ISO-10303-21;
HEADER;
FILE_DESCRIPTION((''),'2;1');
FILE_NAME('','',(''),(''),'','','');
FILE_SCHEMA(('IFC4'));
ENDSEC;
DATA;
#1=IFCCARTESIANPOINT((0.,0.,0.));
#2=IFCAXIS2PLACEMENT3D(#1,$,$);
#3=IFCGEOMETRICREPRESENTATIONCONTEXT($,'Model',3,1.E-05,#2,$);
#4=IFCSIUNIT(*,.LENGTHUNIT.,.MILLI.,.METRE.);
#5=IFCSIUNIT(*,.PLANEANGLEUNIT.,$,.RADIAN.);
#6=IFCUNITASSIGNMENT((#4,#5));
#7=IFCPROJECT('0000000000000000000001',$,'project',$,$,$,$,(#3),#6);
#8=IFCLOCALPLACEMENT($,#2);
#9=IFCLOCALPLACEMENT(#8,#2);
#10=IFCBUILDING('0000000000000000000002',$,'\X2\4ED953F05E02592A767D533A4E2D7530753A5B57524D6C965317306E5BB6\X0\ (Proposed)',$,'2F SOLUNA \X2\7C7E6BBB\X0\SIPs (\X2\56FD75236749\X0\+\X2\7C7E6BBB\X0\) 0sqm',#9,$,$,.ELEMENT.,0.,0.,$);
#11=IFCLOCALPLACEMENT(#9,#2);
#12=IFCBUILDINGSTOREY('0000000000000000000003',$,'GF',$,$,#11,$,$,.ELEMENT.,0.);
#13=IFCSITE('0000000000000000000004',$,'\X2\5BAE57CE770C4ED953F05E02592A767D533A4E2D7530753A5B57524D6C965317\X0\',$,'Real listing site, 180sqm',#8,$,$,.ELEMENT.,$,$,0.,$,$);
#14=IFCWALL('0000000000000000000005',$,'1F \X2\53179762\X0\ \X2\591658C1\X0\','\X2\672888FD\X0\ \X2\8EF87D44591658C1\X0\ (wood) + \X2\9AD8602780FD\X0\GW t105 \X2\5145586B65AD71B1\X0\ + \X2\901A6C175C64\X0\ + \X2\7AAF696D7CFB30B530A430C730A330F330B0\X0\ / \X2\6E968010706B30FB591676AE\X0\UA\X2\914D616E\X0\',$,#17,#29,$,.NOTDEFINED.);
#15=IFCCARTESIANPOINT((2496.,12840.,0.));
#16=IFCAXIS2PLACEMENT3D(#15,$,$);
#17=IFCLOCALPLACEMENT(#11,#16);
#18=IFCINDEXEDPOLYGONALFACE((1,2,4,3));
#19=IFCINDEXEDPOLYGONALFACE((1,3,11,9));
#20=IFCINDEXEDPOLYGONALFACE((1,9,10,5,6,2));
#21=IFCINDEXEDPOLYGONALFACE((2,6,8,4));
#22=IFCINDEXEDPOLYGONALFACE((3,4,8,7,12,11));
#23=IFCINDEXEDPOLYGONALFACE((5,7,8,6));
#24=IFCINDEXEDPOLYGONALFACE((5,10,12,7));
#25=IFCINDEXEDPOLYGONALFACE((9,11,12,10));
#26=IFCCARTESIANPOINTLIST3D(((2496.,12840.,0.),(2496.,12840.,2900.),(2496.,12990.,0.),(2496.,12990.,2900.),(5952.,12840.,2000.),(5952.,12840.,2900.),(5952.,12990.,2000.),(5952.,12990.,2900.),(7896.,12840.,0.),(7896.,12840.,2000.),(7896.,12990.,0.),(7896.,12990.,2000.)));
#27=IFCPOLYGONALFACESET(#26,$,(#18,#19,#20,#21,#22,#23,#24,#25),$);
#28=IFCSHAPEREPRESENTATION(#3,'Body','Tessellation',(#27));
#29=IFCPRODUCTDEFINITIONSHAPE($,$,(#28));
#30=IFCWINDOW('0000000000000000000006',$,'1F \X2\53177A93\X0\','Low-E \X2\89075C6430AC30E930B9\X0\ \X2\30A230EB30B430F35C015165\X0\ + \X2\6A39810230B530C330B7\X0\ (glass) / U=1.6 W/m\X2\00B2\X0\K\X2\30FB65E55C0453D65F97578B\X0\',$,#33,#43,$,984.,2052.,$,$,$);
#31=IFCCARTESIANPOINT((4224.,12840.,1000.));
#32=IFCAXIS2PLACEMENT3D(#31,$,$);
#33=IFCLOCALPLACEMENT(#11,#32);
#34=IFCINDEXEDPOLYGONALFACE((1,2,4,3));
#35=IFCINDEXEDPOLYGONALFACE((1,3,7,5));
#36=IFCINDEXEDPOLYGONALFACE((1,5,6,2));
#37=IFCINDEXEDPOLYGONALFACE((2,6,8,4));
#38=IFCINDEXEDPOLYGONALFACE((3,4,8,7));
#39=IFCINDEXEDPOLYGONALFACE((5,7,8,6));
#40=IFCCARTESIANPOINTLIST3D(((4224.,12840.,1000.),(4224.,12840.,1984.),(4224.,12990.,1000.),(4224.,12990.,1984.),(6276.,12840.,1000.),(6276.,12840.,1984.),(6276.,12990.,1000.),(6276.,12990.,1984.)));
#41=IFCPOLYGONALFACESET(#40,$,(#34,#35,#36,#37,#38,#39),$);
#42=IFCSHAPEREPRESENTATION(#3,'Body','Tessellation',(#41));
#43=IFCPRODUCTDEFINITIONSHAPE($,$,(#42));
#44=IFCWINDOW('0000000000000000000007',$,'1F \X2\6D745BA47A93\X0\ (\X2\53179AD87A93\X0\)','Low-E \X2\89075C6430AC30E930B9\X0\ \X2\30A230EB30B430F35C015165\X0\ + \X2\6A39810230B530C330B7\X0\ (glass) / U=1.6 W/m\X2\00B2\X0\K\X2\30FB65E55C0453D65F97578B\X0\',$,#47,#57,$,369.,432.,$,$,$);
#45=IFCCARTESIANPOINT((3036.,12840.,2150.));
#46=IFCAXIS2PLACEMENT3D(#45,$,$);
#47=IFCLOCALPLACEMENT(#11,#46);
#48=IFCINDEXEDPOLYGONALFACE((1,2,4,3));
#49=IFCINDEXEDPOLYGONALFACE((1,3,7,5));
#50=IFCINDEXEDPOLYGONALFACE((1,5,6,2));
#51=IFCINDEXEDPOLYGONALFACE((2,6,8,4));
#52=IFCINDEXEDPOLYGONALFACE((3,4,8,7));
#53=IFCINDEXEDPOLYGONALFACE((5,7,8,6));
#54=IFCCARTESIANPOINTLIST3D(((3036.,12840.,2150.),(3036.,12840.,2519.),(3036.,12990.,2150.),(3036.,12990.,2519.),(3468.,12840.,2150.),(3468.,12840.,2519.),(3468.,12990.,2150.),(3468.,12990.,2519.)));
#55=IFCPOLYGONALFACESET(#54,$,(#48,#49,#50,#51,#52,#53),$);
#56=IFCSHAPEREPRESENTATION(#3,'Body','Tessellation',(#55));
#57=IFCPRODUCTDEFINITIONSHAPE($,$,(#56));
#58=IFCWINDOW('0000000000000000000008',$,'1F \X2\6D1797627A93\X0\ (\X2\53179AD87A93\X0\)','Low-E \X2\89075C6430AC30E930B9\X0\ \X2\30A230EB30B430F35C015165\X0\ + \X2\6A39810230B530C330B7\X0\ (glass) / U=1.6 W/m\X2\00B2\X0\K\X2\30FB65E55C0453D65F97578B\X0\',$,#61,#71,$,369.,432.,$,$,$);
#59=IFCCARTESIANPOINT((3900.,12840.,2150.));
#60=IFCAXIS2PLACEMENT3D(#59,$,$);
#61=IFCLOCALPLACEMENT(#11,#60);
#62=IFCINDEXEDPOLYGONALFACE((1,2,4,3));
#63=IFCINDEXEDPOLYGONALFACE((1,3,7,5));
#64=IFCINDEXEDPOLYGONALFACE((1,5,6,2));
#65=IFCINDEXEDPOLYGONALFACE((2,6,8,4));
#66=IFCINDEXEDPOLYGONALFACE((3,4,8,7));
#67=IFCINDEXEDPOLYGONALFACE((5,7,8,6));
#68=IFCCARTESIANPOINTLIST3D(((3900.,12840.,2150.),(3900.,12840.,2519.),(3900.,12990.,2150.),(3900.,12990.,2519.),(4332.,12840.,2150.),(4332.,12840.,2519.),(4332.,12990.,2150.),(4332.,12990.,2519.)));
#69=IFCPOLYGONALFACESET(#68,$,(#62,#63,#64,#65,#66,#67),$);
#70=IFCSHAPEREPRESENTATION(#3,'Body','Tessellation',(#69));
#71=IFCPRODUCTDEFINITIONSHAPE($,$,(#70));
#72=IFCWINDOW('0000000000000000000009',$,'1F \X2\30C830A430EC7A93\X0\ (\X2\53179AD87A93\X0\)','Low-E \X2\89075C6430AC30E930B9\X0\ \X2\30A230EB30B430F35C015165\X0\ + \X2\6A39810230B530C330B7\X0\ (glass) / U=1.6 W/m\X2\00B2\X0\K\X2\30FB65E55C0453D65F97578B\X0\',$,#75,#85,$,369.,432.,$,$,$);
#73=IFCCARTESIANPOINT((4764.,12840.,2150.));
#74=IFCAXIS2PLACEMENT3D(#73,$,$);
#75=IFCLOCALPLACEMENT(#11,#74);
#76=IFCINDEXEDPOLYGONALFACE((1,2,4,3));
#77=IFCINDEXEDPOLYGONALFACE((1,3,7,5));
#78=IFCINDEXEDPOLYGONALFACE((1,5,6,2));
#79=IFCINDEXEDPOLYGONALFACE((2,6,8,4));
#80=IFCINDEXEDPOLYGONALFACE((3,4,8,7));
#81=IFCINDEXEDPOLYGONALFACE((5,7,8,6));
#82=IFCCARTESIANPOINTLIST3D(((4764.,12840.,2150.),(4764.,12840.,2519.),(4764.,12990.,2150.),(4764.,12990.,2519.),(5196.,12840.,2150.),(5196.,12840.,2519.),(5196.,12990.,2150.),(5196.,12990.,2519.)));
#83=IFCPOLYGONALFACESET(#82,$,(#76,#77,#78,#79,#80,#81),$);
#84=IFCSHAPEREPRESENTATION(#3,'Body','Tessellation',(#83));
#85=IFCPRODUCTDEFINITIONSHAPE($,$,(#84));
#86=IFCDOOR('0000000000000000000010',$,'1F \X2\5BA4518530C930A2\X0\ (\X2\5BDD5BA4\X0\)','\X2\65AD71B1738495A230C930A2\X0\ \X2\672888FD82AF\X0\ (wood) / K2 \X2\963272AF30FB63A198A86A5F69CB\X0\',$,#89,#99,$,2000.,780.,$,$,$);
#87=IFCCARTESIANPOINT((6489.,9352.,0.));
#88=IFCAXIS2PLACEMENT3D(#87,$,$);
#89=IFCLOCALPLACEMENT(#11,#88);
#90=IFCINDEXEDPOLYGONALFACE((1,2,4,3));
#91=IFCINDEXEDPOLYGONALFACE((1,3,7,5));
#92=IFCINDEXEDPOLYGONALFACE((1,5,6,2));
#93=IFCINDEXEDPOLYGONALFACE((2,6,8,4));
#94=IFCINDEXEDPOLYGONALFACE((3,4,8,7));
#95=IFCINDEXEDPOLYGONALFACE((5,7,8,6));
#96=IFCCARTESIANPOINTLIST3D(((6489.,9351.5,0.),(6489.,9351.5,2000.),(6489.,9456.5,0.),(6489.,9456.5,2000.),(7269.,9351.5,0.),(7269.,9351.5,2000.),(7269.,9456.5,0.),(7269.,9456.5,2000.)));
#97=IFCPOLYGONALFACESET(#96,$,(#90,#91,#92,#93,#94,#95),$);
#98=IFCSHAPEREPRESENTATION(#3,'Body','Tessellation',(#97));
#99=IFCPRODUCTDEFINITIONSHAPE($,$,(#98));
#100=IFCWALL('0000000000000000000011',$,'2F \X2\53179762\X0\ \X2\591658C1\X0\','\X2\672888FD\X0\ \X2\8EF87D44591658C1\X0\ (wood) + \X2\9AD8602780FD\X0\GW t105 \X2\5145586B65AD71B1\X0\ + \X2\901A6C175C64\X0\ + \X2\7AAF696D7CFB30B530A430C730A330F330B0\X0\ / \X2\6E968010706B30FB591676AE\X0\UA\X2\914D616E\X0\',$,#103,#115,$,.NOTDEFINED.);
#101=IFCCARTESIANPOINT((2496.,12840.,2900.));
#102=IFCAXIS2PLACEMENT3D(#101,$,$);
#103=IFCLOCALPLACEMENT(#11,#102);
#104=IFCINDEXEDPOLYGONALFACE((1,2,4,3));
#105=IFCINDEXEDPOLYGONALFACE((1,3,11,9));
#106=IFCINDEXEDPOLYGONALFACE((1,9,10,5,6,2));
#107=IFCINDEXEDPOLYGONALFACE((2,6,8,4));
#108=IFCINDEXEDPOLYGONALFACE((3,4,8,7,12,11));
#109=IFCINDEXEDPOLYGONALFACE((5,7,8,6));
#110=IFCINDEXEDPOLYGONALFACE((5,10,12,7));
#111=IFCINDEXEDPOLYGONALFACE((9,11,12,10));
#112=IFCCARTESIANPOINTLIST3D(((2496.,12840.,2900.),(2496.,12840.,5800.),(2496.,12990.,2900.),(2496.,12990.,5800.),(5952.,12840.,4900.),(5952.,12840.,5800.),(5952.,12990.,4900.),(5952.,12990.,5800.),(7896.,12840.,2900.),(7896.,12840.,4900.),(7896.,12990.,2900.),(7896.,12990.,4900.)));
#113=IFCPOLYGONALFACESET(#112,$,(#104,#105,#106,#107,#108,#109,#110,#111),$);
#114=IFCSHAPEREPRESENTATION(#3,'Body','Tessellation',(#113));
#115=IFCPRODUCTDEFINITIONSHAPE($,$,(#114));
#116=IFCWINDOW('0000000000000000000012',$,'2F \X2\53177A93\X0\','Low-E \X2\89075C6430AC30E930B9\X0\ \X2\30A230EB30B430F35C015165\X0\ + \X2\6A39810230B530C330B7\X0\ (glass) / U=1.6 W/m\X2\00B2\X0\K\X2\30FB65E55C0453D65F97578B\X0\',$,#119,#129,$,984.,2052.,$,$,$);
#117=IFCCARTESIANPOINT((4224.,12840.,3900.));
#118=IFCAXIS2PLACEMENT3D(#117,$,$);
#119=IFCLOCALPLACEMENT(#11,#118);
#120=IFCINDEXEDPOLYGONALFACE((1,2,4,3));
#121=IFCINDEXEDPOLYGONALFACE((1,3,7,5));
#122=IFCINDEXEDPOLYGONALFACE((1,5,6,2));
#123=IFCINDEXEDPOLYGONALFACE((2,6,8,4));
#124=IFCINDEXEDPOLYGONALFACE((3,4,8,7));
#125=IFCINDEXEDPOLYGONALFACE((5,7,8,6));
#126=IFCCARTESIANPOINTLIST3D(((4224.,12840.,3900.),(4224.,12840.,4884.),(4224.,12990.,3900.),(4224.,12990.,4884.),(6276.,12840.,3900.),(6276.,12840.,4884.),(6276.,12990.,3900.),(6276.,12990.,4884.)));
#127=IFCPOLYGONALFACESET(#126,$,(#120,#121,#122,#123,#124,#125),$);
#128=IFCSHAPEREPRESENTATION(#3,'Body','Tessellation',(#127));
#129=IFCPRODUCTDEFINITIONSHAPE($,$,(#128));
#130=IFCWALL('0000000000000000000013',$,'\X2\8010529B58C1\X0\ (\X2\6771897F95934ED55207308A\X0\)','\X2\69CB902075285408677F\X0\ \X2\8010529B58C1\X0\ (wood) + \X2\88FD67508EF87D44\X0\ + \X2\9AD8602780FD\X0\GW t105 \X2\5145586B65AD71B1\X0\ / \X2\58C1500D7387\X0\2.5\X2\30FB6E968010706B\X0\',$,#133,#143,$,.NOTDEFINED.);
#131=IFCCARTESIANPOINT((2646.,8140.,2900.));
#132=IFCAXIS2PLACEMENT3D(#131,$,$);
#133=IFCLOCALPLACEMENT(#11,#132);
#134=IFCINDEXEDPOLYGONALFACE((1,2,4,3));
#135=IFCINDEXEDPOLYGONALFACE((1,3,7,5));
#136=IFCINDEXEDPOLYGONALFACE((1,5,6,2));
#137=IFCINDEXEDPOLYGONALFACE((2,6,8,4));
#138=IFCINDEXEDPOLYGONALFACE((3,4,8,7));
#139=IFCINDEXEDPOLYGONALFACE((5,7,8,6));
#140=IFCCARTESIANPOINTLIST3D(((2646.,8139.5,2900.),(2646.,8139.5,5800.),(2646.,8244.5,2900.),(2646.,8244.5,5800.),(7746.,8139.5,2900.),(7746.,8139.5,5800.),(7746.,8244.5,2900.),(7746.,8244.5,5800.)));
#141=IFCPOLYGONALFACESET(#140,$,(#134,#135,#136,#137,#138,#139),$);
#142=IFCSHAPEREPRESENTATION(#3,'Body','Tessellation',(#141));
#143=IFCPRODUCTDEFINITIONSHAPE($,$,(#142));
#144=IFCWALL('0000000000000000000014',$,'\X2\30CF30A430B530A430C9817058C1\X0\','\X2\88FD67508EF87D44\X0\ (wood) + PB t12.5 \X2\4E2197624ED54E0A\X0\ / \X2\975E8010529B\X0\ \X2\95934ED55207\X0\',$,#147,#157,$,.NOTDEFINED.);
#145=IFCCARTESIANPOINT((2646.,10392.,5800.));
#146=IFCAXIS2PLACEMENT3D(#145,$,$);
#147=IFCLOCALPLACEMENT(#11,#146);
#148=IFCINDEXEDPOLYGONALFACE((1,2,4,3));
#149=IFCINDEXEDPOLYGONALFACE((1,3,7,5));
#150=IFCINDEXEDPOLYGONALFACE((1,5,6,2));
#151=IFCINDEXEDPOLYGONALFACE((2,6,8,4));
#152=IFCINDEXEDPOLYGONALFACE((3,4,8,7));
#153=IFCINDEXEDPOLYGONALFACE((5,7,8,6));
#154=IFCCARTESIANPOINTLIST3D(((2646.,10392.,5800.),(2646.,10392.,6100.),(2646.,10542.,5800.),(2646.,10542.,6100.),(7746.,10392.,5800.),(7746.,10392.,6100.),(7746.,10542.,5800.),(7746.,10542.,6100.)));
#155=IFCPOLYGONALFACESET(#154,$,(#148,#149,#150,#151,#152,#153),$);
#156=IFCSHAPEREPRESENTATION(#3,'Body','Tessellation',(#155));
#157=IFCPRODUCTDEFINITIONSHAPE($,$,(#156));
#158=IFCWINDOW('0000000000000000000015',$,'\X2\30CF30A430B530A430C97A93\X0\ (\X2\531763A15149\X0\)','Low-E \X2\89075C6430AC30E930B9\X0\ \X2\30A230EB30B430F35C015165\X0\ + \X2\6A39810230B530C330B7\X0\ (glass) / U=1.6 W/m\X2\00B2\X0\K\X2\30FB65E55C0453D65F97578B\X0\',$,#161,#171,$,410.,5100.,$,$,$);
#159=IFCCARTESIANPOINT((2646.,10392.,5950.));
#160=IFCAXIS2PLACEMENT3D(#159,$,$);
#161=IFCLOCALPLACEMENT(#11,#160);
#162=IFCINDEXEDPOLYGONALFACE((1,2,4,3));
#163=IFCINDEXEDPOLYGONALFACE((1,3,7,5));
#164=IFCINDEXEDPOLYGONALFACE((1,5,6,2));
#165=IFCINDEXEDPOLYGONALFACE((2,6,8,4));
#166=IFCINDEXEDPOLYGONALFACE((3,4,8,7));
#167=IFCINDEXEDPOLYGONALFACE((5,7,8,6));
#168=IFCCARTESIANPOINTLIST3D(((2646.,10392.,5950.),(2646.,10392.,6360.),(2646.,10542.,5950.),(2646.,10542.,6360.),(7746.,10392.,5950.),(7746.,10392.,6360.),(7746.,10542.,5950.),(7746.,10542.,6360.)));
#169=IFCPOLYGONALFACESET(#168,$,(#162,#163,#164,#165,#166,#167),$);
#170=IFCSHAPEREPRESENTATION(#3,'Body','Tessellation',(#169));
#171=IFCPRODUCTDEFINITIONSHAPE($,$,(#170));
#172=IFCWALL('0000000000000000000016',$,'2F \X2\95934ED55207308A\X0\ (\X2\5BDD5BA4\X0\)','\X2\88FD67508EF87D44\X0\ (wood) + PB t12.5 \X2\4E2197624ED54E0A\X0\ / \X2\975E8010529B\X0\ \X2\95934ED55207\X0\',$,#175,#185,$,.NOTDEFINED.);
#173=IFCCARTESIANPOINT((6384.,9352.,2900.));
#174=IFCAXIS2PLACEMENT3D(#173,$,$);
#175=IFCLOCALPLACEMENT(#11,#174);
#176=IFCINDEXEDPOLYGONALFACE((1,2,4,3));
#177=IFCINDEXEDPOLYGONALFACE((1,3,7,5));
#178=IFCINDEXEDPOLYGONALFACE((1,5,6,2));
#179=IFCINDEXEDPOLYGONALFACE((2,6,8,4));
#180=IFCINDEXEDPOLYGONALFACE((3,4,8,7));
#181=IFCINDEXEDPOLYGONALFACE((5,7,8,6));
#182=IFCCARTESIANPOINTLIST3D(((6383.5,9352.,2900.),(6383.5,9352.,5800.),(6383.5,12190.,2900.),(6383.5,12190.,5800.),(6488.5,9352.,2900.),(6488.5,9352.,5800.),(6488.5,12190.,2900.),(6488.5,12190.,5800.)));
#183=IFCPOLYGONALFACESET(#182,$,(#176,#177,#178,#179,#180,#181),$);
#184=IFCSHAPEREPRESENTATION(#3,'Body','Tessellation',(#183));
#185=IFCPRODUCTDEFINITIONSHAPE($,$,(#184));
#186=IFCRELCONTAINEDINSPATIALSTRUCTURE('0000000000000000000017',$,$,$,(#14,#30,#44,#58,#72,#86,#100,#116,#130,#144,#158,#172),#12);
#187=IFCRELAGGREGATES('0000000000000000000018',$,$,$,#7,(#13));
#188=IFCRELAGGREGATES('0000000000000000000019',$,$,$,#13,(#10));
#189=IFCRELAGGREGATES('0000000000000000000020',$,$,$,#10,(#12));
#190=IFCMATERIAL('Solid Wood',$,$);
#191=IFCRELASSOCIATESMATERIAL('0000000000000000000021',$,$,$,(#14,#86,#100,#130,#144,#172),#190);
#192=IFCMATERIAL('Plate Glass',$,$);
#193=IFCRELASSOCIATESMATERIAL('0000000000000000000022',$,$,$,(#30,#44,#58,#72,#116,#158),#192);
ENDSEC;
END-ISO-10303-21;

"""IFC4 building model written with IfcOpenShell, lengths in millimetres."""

from ifc_helpers import new_model, si_unit, frame, frame_2d, origin, place, context, project, spatial, rectangle, extrude, material, element, fill, save


model = new_model("IFC4")

# Units and contexts
model_context = context("Model", 3, precision=1e-05, world=origin())
ifc_project = project(units=[si_unit("LENGTHUNIT", "METRE", prefix="MILLI"), si_unit("PLANEANGLEUNIT", "RADIAN")], contexts=[model_context])

# Site, building, storey
site_placement = place(None, origin())
site = spatial("IfcSite", under=ifc_project, at=site_placement, Name="宮城県仙台市太白区中田町字前沖北", ObjectType="Real listing site, 180sqm", CompositionType="ELEMENT", RefElevation=0.0)
building_placement = place(site_placement, origin())
building = spatial("IfcBuilding", under=site, at=building_placement, Name="仙台市太白区中田町字前沖北の家 (Proposed)", ObjectType="2F SOLUNA 籾殻SIPs (国産杉+籾殻) 0sqm", CompositionType="ELEMENT", ElevationOfRefHeight=0.0, ElevationOfTerrain=0.0)
storey_placement = place(building_placement, origin())
storey = spatial("IfcBuildingStorey", under=building, at=storey_placement, Name="GF", CompositionType="ELEMENT", Elevation=0.0)

# Wall, openings, windows
ifc_material_1 = material(Name="Solid Wood")
wall_1_placement = place(storey_placement, frame((2496.0, 12840.0, 0.0)))
wall_1 = element("IfcWall", 1, at=wall_1_placement, inside=storey, material=ifc_material_1, Name="1F 北面 外壁", Description="木製 軸組外壁 (wood) + 高性能GW t105 充填断熱 + 通気層 + 窯業系サイディング / 準耐火・外皮UA配慮", PredefinedType="NOTDEFINED", context=model_context, shape_type="SweptSolid", body=[
    extrude(rectangle(XDim=5400.0, YDim=150.0, at=frame_2d((2700.0, 75.0))), frame((2496.0, 12840.0, 0.0)), (0.0, 0.0, 1.0), 2900.0),
])
opening_1_placement = place(storey_placement, frame((4224.0, 12840.0, 1000.0)))
opening_1 = element("IfcOpeningElement", 2, at=opening_1_placement, cuts=wall_1, PredefinedType="NOTDEFINED", context=model_context, shape_type="SweptSolid", body=[
    extrude(rectangle(XDim=2052.0, YDim=150.0, at=frame_2d((1026.0, 75.0))), frame((4224.0, 12840.0, 1000.0)), (0.0, 0.0, 1.0), 984.0),
])
opening_2_placement = place(storey_placement, frame((3036.0, 12840.0, 2150.0)))
opening_2 = element("IfcOpeningElement", 3, at=opening_2_placement, cuts=wall_1, PredefinedType="NOTDEFINED", context=model_context, shape_type="SweptSolid", body=[
    extrude(rectangle(XDim=432.0, YDim=150.0, at=frame_2d((216.0, 75.0))), frame((3036.0, 12840.0, 2150.0)), (0.0, 0.0, 1.0), 369.0),
])
opening_3_placement = place(storey_placement, frame((3900.0, 12840.0, 2150.0)))
opening_3 = element("IfcOpeningElement", 4, at=opening_3_placement, cuts=wall_1, PredefinedType="NOTDEFINED", context=model_context, shape_type="SweptSolid", body=[
    extrude(rectangle(XDim=432.0, YDim=150.0, at=frame_2d((216.0, 75.0))), frame((3900.0, 12840.0, 2150.0)), (0.0, 0.0, 1.0), 369.0),
])
opening_4_placement = place(storey_placement, frame((4764.0, 12840.0, 2150.0)))
opening_4 = element("IfcOpeningElement", 5, at=opening_4_placement, cuts=wall_1, PredefinedType="NOTDEFINED", context=model_context, shape_type="SweptSolid", body=[
    extrude(rectangle(XDim=432.0, YDim=150.0, at=frame_2d((216.0, 75.0))), frame((4764.0, 12840.0, 2150.0)), (0.0, 0.0, 1.0), 369.0),
])
ifc_material_2 = material(Name="Plate Glass")
window_1_placement = place(storey_placement, frame((4224.0, 12840.0, 1000.0)))
window_1 = element("IfcWindow", 6, at=window_1_placement, inside=storey, material=ifc_material_2, Name="1F 北窓", Description="Low-E 複層ガラス アルゴン封入 + 樹脂サッシ (glass) / U=1.6 W/m²K・日射取得型", OverallHeight=984.0, OverallWidth=2052.0, context=model_context, shape_type="SweptSolid", body=[
    extrude(rectangle(XDim=2052.0, YDim=150.0, at=frame_2d((1026.0, 75.0))), frame((4224.0, 12840.0, 1000.0)), (0.0, 0.0, 1.0), 984.0),
])
fill(opening_1, window_1)
window_2_placement = place(storey_placement, frame((3036.0, 12840.0, 2150.0)))
window_2 = element("IfcWindow", 7, at=window_2_placement, inside=storey, material=ifc_material_2, Name="1F 浴室窓 (北高窓)", Description="Low-E 複層ガラス アルゴン封入 + 樹脂サッシ (glass) / U=1.6 W/m²K・日射取得型", OverallHeight=369.0, OverallWidth=432.0, context=model_context, shape_type="SweptSolid", body=[
    extrude(rectangle(XDim=432.0, YDim=150.0, at=frame_2d((216.0, 75.0))), frame((3036.0, 12840.0, 2150.0)), (0.0, 0.0, 1.0), 369.0),
])
fill(opening_2, window_2)
window_3_placement = place(storey_placement, frame((3900.0, 12840.0, 2150.0)))
window_3 = element("IfcWindow", 8, at=window_3_placement, inside=storey, material=ifc_material_2, Name="1F 洗面窓 (北高窓)", Description="Low-E 複層ガラス アルゴン封入 + 樹脂サッシ (glass) / U=1.6 W/m²K・日射取得型", OverallHeight=369.0, OverallWidth=432.0, context=model_context, shape_type="SweptSolid", body=[
    extrude(rectangle(XDim=432.0, YDim=150.0, at=frame_2d((216.0, 75.0))), frame((3900.0, 12840.0, 2150.0)), (0.0, 0.0, 1.0), 369.0),
])
fill(opening_3, window_3)
window_4_placement = place(storey_placement, frame((4764.0, 12840.0, 2150.0)))
window_4 = element("IfcWindow", 9, at=window_4_placement, inside=storey, material=ifc_material_2, Name="1F トイレ窓 (北高窓)", Description="Low-E 複層ガラス アルゴン封入 + 樹脂サッシ (glass) / U=1.6 W/m²K・日射取得型", OverallHeight=369.0, OverallWidth=432.0, context=model_context, shape_type="SweptSolid", body=[
    extrude(rectangle(XDim=432.0, YDim=150.0, at=frame_2d((216.0, 75.0))), frame((4764.0, 12840.0, 2150.0)), (0.0, 0.0, 1.0), 369.0),
])
fill(opening_4, window_4)

# Door
door_1_placement = place(storey_placement, frame((6489.0, 9352.0, 0.0)))
element("IfcDoor", 10, at=door_1_placement, inside=storey, material=ifc_material_1, Name="1F 室内ドア (寝室)", Description="断熱玄関ドア 木製芯 (wood) / K2 防犯・採風機構", OverallHeight=2000.0, OverallWidth=780.0, context=model_context, shape_type="SweptSolid", body=[
    extrude(rectangle(XDim=780.0, YDim=105.0, at=frame_2d((390.0, 52.0))), frame((6489.0, 9352.0, 0.0)), (0.0, 0.0, 1.0), 2000.0),
])

# Wall, opening, window
wall_2_placement = place(storey_placement, frame((2496.0, 12840.0, 2900.0)))
wall_2 = element("IfcWall", 11, at=wall_2_placement, inside=storey, material=ifc_material_1, Name="2F 北面 外壁", Description="木製 軸組外壁 (wood) + 高性能GW t105 充填断熱 + 通気層 + 窯業系サイディング / 準耐火・外皮UA配慮", PredefinedType="NOTDEFINED", context=model_context, shape_type="SweptSolid", body=[
    extrude(rectangle(XDim=5400.0, YDim=150.0, at=frame_2d((2700.0, 75.0))), frame((2496.0, 12840.0, 2900.0)), (0.0, 0.0, 1.0), 2900.0),
])
opening_5_placement = place(storey_placement, frame((4224.0, 12840.0, 3900.0)))
opening_5 = element("IfcOpeningElement", 12, at=opening_5_placement, cuts=wall_2, PredefinedType="NOTDEFINED", context=model_context, shape_type="SweptSolid", body=[
    extrude(rectangle(XDim=2052.0, YDim=150.0, at=frame_2d((1026.0, 75.0))), frame((4224.0, 12840.0, 3900.0)), (0.0, 0.0, 1.0), 984.0),
])
window_5_placement = place(storey_placement, frame((4224.0, 12840.0, 3900.0)))
window_5 = element("IfcWindow", 13, at=window_5_placement, inside=storey, material=ifc_material_2, Name="2F 北窓", Description="Low-E 複層ガラス アルゴン封入 + 樹脂サッシ (glass) / U=1.6 W/m²K・日射取得型", OverallHeight=984.0, OverallWidth=2052.0, context=model_context, shape_type="SweptSolid", body=[
    extrude(rectangle(XDim=2052.0, YDim=150.0, at=frame_2d((1026.0, 75.0))), frame((4224.0, 12840.0, 3900.0)), (0.0, 0.0, 1.0), 984.0),
])
fill(opening_5, window_5)

# Wall
wall_3_placement = place(storey_placement, frame((2646.0, 8140.0, 2900.0)))
element("IfcWall", 14, at=wall_3_placement, inside=storey, material=ifc_material_1, Name="耐力壁 (東西間仕切り)", Description="構造用合板 耐力壁 (wood) + 製材軸組 + 高性能GW t105 充填断熱 / 壁倍率2.5・準耐火", PredefinedType="NOTDEFINED", context=model_context, shape_type="SweptSolid", body=[
    extrude(rectangle(XDim=5100.0, YDim=105.0, at=frame_2d((2550.0, 52.0))), frame((2646.0, 8140.0, 2900.0)), (0.0, 0.0, 1.0), 2900.0),
])

# Wall, opening, window
wall_4_placement = place(storey_placement, frame((2646.0, 10392.0, 5800.0)))
wall_4 = element("IfcWall", 15, at=wall_4_placement, inside=storey, material=ifc_material_1, Name="ハイサイド腰壁", Description="製材軸組 (wood) + PB t12.5 両面仕上 / 非耐力 間仕切", PredefinedType="NOTDEFINED", context=model_context, shape_type="SweptSolid", body=[
    extrude(rectangle(XDim=5100.0, YDim=150.0, at=frame_2d((2550.0, 75.0))), frame((2646.0, 10392.0, 5800.0)), (0.0, 0.0, 1.0), 700.0),
])
opening_6_placement = place(storey_placement, frame((2646.0, 10392.0, 5950.0)))
opening_6 = element("IfcOpeningElement", 16, at=opening_6_placement, cuts=wall_4, PredefinedType="NOTDEFINED", context=model_context, shape_type="SweptSolid", body=[
    extrude(rectangle(XDim=5100.0, YDim=150.0, at=frame_2d((2550.0, 75.0))), frame((2646.0, 10392.0, 5950.0)), (0.0, 0.0, 1.0), 410.0),
])
window_6_placement = place(storey_placement, frame((2646.0, 10392.0, 5950.0)))
window_6 = element("IfcWindow", 17, at=window_6_placement, inside=storey, material=ifc_material_2, Name="ハイサイド窓 (北採光)", Description="Low-E 複層ガラス アルゴン封入 + 樹脂サッシ (glass) / U=1.6 W/m²K・日射取得型", OverallHeight=410.0, OverallWidth=5100.0, context=model_context, shape_type="SweptSolid", body=[
    extrude(rectangle(XDim=5100.0, YDim=150.0, at=frame_2d((2550.0, 75.0))), frame((2646.0, 10392.0, 5950.0)), (0.0, 0.0, 1.0), 410.0),
])
fill(opening_6, window_6)

# Wall
wall_5_placement = place(storey_placement, frame((6384.0, 9352.0, 2900.0)))
element("IfcWall", 18, at=wall_5_placement, inside=storey, material=ifc_material_1, Name="2F 間仕切り (寝室)", Description="製材軸組 (wood) + PB t12.5 両面仕上 / 非耐力 間仕切", PredefinedType="NOTDEFINED", context=model_context, shape_type="SweptSolid", body=[
    extrude(rectangle(XDim=105.0, YDim=2838.0, at=frame_2d((52.0, 1419.0))), frame((6384.0, 9352.0, 2900.0)), (0.0, 0.0, 1.0), 2900.0),
])

save(model, "model.ifc")
